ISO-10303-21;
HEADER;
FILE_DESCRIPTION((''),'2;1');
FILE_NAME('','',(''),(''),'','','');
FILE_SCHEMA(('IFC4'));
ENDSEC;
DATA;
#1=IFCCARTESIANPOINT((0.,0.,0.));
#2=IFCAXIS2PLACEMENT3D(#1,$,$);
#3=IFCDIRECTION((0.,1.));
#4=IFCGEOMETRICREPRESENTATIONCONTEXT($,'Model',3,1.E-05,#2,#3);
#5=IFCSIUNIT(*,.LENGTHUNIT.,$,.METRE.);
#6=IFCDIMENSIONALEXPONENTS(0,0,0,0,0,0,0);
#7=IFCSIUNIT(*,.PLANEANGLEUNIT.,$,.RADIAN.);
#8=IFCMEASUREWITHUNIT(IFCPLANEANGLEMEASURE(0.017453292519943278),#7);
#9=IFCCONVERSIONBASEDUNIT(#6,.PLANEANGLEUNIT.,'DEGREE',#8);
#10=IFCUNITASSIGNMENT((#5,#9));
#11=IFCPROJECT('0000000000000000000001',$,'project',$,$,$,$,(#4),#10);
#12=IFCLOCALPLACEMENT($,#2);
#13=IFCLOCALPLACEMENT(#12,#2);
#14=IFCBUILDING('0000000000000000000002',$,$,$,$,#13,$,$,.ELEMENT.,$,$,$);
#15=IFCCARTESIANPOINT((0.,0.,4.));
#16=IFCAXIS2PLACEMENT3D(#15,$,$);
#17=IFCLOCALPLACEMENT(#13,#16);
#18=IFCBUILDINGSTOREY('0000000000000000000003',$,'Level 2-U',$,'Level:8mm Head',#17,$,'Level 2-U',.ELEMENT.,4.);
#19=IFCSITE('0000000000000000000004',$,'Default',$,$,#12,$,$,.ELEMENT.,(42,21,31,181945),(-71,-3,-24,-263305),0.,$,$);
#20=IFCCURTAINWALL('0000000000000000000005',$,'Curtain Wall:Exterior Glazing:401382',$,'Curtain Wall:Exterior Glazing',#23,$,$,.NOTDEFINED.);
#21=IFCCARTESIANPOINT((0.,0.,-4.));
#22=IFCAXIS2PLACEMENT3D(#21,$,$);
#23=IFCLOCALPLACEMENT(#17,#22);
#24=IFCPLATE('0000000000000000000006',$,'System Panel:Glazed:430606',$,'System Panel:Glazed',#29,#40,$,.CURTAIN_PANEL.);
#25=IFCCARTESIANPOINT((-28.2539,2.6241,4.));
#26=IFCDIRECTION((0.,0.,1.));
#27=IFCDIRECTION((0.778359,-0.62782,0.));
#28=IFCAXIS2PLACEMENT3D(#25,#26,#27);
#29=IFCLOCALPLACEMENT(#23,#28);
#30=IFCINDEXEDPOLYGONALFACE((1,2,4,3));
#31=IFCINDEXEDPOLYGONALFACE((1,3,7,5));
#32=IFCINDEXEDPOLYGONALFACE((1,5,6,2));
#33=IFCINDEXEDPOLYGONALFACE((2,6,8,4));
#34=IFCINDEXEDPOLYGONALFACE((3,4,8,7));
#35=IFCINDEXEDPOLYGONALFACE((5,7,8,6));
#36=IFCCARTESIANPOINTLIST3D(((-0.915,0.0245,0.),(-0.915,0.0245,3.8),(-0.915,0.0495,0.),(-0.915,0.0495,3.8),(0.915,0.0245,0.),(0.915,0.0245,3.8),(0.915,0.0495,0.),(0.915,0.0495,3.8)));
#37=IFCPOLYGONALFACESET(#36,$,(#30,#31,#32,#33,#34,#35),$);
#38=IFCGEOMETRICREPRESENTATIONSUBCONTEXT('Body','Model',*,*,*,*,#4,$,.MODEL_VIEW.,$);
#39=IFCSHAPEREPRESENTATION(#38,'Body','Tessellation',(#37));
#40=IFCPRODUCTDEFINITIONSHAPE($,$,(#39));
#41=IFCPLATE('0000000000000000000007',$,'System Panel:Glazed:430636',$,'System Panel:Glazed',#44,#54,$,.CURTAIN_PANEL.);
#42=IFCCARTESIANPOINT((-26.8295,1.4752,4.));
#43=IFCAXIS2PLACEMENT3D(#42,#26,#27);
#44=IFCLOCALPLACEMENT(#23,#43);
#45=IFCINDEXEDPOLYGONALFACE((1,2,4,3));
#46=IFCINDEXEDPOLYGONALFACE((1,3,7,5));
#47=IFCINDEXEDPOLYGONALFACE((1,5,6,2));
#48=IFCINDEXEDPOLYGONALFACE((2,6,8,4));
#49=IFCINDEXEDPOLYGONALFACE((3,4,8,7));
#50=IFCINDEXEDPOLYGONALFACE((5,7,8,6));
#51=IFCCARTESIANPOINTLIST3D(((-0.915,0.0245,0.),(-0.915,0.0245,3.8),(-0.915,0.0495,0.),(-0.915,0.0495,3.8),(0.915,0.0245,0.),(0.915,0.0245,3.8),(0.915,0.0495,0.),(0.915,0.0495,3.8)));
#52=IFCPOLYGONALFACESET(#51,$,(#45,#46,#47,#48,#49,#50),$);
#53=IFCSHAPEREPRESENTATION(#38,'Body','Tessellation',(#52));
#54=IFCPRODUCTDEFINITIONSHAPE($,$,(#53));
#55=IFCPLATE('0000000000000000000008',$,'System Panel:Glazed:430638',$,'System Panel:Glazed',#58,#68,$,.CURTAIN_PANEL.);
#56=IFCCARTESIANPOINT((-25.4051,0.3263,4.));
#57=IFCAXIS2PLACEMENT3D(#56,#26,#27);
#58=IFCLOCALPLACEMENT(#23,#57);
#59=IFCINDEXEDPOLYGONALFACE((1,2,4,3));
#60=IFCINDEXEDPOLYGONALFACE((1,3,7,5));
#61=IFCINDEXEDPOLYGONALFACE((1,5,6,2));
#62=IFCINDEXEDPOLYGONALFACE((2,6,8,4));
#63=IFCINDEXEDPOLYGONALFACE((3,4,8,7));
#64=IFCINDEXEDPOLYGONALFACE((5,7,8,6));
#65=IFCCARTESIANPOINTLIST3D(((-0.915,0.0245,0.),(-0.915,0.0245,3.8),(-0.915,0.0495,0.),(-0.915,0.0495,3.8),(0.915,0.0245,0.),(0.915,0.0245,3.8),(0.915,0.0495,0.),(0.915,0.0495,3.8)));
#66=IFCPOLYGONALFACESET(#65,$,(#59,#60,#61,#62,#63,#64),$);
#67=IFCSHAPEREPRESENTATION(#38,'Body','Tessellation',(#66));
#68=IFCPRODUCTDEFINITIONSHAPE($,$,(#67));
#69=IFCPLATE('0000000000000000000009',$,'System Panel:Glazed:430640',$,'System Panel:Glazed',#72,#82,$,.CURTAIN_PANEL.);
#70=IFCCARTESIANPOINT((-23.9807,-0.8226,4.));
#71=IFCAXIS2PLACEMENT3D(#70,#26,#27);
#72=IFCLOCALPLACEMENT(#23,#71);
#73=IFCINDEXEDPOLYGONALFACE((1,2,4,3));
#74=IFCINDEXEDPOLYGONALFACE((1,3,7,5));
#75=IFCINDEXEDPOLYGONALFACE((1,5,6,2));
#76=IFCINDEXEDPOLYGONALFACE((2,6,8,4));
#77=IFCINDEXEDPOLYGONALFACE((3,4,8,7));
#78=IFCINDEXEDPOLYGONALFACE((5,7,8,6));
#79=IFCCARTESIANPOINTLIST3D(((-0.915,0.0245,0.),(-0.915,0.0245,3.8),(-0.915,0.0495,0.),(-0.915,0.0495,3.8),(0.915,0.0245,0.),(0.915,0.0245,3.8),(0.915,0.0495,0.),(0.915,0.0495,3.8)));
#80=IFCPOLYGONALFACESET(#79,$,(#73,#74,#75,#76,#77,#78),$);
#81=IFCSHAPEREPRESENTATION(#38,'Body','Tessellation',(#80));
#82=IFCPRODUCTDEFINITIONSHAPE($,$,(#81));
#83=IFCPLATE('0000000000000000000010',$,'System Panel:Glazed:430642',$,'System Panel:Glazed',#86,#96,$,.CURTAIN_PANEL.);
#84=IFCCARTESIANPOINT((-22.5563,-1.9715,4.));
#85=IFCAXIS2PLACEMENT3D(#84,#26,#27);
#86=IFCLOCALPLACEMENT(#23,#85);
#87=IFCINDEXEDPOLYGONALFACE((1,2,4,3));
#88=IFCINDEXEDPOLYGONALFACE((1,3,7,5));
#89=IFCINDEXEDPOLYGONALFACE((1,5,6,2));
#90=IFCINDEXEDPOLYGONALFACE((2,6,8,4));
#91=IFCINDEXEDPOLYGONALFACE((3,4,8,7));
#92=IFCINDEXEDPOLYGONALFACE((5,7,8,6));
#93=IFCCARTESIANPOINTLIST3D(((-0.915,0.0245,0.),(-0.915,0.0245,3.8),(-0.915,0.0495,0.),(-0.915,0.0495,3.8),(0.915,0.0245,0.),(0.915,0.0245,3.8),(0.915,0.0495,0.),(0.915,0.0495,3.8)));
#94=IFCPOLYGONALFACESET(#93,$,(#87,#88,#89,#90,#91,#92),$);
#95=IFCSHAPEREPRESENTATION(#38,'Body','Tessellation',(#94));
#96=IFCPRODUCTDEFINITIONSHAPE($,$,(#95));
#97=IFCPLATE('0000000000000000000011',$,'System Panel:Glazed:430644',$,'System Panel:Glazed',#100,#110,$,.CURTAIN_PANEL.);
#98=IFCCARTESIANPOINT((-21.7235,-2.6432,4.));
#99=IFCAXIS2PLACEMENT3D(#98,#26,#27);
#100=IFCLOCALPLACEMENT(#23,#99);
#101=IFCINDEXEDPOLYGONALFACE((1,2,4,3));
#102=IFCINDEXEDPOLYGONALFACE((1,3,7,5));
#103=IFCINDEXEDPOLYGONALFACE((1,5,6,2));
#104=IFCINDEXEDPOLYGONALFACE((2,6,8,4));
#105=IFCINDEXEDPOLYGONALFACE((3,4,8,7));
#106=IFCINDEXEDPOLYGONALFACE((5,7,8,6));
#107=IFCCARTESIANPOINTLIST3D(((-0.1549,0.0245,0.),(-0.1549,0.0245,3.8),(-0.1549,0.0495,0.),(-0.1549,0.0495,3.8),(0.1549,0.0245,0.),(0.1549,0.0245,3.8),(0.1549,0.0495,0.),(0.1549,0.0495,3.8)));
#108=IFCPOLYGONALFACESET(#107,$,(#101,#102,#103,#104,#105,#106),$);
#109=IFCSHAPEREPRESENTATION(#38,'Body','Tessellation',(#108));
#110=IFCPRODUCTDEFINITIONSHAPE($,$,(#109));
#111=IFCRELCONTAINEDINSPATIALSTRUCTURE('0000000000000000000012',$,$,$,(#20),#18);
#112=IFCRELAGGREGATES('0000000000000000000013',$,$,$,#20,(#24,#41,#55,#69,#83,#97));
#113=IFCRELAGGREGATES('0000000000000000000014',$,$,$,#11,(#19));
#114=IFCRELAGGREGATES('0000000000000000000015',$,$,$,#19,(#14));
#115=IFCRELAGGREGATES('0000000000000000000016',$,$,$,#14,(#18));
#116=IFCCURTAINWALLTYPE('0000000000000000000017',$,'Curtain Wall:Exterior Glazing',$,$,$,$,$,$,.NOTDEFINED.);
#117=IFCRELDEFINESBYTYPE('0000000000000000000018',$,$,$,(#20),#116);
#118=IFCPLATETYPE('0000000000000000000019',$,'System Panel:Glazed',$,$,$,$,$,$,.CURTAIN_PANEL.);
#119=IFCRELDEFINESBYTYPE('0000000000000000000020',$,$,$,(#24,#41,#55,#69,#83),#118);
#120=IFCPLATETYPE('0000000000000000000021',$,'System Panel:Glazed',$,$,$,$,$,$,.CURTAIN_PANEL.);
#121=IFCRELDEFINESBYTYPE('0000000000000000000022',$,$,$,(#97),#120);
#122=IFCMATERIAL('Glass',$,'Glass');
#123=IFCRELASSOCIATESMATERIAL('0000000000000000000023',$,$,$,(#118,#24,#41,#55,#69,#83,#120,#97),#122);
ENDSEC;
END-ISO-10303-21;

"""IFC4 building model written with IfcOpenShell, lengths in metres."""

from ifc_helpers import new_model, entity, si_unit, converted_unit, direction, frame, origin, place, context, subcontext, project, spatial, indexed_curve, outline, extrude, source, transform, mapped, material, type_object, type_shapes, element, aggregate, save


model = new_model("IFC4")

# Units and contexts
model_context = context("Model", 3, precision=1e-05, world=origin(), true_north=direction((0.0, 1.0)))
body_context = subcontext(model_context, "Body", "Model", "MODEL_VIEW")
ifc_project = project(units=[si_unit("LENGTHUNIT", "METRE"), converted_unit("PLANEANGLEUNIT", "DEGREE", entity("IfcPlaneAngleMeasure", 0.017453292519943278), si_unit("PLANEANGLEUNIT", "RADIAN"), dimensions=[0, 0, 0, 0, 0, 0, 0])], contexts=[model_context])

# Site, building, storey
site_placement = place(None, origin())
site = spatial("IfcSite", under=ifc_project, at=site_placement, Name="Default", CompositionType="ELEMENT", RefLatitude=(42, 21, 31, 181945), RefLongitude=(-71, -3, -24, -263305), RefElevation=0.0)
building_placement = place(site_placement, origin())
building = spatial("IfcBuilding", under=site, at=building_placement, CompositionType="ELEMENT")
storey_placement = place(building_placement, frame((0.0, 0.0, 4.0)))
storey = spatial("IfcBuildingStorey", under=building, at=storey_placement, Name="Level 2-U", ObjectType="Level:8mm Head", LongName="Level 2-U", CompositionType="ELEMENT", Elevation=4.0)

# Curtain wall, plates
curtain_wall_type = type_object("IfcCurtainWallType", Name="Curtain Wall:Exterior Glazing", PredefinedType="NOTDEFINED")
curtain_wall_placement = place(storey_placement, frame((0.0, 0.0, -4.0)))
curtain_wall = element("IfcCurtainWall", 1, at=curtain_wall_placement, inside=storey, type_object=curtain_wall_type, Name="Curtain Wall:Exterior Glazing:401382", ObjectType="Curtain Wall:Exterior Glazing", PredefinedType="NOTDEFINED")
ifc_material_1 = material(Name="Glass", Category="Glass")
plate_type_1 = type_object("IfcPlateType", Name="System Panel:Glazed", PredefinedType="CURTAIN_PANEL", material=ifc_material_1)
shared_shape_1 = source(origin(), body_context, "Body", "SweptSolid", [
    extrude(outline(indexed_curve([(-0.0125, -0.915), (0.0125, -0.915), (0.0125, 0.915), (-0.0125, 0.915), (-0.0125, -0.915)], self_intersect=False)), frame((0.0, 0.037, 0.0), z_axis=(0.0, 0.0, 1.0), x_axis=(0.0, 1.0, 0.0)), (0.0, 0.0, 1.0), 3.8),
])
type_shapes(plate_type_1, [shared_shape_1])
plate_1_placement = place(curtain_wall_placement, frame((-28.2539, 2.6241, 4.0), z_axis=(0.0, 0.0, 1.0), x_axis=(0.778359, -0.62782, 0.0)))
plate_1 = element("IfcPlate", 2, at=plate_1_placement, type_object=plate_type_1, material=ifc_material_1, Name="System Panel:Glazed:430606", ObjectType="System Panel:Glazed", PredefinedType="CURTAIN_PANEL", context=body_context, shape_type="MappedRepresentation", body=[
    mapped(shared_shape_1, transform((0.0, 0.0, 0.0), scale=1.0)),
])
plate_2_placement = place(curtain_wall_placement, frame((-26.8295, 1.4752, 4.0), z_axis=(0.0, 0.0, 1.0), x_axis=(0.778359, -0.62782, 0.0)))
plate_2 = element("IfcPlate", 3, at=plate_2_placement, type_object=plate_type_1, material=ifc_material_1, Name="System Panel:Glazed:430636", ObjectType="System Panel:Glazed", PredefinedType="CURTAIN_PANEL", context=body_context, shape_type="MappedRepresentation", body=[
    mapped(shared_shape_1, transform((0.0, 0.0, 0.0), scale=1.0)),
])
plate_3_placement = place(curtain_wall_placement, frame((-25.4051, 0.3263, 4.0), z_axis=(0.0, 0.0, 1.0), x_axis=(0.778359, -0.62782, 0.0)))
plate_3 = element("IfcPlate", 4, at=plate_3_placement, type_object=plate_type_1, material=ifc_material_1, Name="System Panel:Glazed:430638", ObjectType="System Panel:Glazed", PredefinedType="CURTAIN_PANEL", context=body_context, shape_type="MappedRepresentation", body=[
    mapped(shared_shape_1, transform((0.0, 0.0, 0.0), scale=1.0)),
])
plate_4_placement = place(curtain_wall_placement, frame((-23.9807, -0.8226, 4.0), z_axis=(0.0, 0.0, 1.0), x_axis=(0.778359, -0.62782, 0.0)))
plate_4 = element("IfcPlate", 5, at=plate_4_placement, type_object=plate_type_1, material=ifc_material_1, Name="System Panel:Glazed:430640", ObjectType="System Panel:Glazed", PredefinedType="CURTAIN_PANEL", context=body_context, shape_type="MappedRepresentation", body=[
    mapped(shared_shape_1, transform((0.0, 0.0, 0.0), scale=1.0)),
])
plate_5_placement = place(curtain_wall_placement, frame((-22.5563, -1.9715, 4.0), z_axis=(0.0, 0.0, 1.0), x_axis=(0.778359, -0.62782, 0.0)))
plate_5 = element("IfcPlate", 6, at=plate_5_placement, type_object=plate_type_1, material=ifc_material_1, Name="System Panel:Glazed:430642", ObjectType="System Panel:Glazed", PredefinedType="CURTAIN_PANEL", context=body_context, shape_type="MappedRepresentation", body=[
    mapped(shared_shape_1, transform((0.0, 0.0, 0.0), scale=1.0)),
])
plate_type_2 = type_object("IfcPlateType", Name="System Panel:Glazed", PredefinedType="CURTAIN_PANEL", material=ifc_material_1)
shared_shape_2 = source(origin(), body_context, "Body", "SweptSolid", [
    extrude(outline(indexed_curve([(-0.0125, -0.1549), (0.0125, -0.1549), (0.0125, 0.1549), (-0.0125, 0.1549), (-0.0125, -0.1549)], self_intersect=False)), frame((0.0, 0.037, 0.0), z_axis=(0.0, 0.0, 1.0), x_axis=(0.0, 1.0, 0.0)), (0.0, 0.0, 1.0), 3.8),
])
type_shapes(plate_type_2, [shared_shape_2])
plate_6_placement = place(curtain_wall_placement, frame((-21.7235, -2.6432, 4.0), z_axis=(0.0, 0.0, 1.0), x_axis=(0.778359, -0.62782, 0.0)))
plate_6 = element("IfcPlate", 7, at=plate_6_placement, type_object=plate_type_2, material=ifc_material_1, Name="System Panel:Glazed:430644", ObjectType="System Panel:Glazed", PredefinedType="CURTAIN_PANEL", context=body_context, shape_type="MappedRepresentation", body=[
    mapped(shared_shape_2, transform((0.0, 0.0, 0.0), scale=1.0)),
])
aggregate(curtain_wall, [plate_1, plate_2, plate_3, plate_4, plate_5, plate_6])

save(model, "model.ifc")
